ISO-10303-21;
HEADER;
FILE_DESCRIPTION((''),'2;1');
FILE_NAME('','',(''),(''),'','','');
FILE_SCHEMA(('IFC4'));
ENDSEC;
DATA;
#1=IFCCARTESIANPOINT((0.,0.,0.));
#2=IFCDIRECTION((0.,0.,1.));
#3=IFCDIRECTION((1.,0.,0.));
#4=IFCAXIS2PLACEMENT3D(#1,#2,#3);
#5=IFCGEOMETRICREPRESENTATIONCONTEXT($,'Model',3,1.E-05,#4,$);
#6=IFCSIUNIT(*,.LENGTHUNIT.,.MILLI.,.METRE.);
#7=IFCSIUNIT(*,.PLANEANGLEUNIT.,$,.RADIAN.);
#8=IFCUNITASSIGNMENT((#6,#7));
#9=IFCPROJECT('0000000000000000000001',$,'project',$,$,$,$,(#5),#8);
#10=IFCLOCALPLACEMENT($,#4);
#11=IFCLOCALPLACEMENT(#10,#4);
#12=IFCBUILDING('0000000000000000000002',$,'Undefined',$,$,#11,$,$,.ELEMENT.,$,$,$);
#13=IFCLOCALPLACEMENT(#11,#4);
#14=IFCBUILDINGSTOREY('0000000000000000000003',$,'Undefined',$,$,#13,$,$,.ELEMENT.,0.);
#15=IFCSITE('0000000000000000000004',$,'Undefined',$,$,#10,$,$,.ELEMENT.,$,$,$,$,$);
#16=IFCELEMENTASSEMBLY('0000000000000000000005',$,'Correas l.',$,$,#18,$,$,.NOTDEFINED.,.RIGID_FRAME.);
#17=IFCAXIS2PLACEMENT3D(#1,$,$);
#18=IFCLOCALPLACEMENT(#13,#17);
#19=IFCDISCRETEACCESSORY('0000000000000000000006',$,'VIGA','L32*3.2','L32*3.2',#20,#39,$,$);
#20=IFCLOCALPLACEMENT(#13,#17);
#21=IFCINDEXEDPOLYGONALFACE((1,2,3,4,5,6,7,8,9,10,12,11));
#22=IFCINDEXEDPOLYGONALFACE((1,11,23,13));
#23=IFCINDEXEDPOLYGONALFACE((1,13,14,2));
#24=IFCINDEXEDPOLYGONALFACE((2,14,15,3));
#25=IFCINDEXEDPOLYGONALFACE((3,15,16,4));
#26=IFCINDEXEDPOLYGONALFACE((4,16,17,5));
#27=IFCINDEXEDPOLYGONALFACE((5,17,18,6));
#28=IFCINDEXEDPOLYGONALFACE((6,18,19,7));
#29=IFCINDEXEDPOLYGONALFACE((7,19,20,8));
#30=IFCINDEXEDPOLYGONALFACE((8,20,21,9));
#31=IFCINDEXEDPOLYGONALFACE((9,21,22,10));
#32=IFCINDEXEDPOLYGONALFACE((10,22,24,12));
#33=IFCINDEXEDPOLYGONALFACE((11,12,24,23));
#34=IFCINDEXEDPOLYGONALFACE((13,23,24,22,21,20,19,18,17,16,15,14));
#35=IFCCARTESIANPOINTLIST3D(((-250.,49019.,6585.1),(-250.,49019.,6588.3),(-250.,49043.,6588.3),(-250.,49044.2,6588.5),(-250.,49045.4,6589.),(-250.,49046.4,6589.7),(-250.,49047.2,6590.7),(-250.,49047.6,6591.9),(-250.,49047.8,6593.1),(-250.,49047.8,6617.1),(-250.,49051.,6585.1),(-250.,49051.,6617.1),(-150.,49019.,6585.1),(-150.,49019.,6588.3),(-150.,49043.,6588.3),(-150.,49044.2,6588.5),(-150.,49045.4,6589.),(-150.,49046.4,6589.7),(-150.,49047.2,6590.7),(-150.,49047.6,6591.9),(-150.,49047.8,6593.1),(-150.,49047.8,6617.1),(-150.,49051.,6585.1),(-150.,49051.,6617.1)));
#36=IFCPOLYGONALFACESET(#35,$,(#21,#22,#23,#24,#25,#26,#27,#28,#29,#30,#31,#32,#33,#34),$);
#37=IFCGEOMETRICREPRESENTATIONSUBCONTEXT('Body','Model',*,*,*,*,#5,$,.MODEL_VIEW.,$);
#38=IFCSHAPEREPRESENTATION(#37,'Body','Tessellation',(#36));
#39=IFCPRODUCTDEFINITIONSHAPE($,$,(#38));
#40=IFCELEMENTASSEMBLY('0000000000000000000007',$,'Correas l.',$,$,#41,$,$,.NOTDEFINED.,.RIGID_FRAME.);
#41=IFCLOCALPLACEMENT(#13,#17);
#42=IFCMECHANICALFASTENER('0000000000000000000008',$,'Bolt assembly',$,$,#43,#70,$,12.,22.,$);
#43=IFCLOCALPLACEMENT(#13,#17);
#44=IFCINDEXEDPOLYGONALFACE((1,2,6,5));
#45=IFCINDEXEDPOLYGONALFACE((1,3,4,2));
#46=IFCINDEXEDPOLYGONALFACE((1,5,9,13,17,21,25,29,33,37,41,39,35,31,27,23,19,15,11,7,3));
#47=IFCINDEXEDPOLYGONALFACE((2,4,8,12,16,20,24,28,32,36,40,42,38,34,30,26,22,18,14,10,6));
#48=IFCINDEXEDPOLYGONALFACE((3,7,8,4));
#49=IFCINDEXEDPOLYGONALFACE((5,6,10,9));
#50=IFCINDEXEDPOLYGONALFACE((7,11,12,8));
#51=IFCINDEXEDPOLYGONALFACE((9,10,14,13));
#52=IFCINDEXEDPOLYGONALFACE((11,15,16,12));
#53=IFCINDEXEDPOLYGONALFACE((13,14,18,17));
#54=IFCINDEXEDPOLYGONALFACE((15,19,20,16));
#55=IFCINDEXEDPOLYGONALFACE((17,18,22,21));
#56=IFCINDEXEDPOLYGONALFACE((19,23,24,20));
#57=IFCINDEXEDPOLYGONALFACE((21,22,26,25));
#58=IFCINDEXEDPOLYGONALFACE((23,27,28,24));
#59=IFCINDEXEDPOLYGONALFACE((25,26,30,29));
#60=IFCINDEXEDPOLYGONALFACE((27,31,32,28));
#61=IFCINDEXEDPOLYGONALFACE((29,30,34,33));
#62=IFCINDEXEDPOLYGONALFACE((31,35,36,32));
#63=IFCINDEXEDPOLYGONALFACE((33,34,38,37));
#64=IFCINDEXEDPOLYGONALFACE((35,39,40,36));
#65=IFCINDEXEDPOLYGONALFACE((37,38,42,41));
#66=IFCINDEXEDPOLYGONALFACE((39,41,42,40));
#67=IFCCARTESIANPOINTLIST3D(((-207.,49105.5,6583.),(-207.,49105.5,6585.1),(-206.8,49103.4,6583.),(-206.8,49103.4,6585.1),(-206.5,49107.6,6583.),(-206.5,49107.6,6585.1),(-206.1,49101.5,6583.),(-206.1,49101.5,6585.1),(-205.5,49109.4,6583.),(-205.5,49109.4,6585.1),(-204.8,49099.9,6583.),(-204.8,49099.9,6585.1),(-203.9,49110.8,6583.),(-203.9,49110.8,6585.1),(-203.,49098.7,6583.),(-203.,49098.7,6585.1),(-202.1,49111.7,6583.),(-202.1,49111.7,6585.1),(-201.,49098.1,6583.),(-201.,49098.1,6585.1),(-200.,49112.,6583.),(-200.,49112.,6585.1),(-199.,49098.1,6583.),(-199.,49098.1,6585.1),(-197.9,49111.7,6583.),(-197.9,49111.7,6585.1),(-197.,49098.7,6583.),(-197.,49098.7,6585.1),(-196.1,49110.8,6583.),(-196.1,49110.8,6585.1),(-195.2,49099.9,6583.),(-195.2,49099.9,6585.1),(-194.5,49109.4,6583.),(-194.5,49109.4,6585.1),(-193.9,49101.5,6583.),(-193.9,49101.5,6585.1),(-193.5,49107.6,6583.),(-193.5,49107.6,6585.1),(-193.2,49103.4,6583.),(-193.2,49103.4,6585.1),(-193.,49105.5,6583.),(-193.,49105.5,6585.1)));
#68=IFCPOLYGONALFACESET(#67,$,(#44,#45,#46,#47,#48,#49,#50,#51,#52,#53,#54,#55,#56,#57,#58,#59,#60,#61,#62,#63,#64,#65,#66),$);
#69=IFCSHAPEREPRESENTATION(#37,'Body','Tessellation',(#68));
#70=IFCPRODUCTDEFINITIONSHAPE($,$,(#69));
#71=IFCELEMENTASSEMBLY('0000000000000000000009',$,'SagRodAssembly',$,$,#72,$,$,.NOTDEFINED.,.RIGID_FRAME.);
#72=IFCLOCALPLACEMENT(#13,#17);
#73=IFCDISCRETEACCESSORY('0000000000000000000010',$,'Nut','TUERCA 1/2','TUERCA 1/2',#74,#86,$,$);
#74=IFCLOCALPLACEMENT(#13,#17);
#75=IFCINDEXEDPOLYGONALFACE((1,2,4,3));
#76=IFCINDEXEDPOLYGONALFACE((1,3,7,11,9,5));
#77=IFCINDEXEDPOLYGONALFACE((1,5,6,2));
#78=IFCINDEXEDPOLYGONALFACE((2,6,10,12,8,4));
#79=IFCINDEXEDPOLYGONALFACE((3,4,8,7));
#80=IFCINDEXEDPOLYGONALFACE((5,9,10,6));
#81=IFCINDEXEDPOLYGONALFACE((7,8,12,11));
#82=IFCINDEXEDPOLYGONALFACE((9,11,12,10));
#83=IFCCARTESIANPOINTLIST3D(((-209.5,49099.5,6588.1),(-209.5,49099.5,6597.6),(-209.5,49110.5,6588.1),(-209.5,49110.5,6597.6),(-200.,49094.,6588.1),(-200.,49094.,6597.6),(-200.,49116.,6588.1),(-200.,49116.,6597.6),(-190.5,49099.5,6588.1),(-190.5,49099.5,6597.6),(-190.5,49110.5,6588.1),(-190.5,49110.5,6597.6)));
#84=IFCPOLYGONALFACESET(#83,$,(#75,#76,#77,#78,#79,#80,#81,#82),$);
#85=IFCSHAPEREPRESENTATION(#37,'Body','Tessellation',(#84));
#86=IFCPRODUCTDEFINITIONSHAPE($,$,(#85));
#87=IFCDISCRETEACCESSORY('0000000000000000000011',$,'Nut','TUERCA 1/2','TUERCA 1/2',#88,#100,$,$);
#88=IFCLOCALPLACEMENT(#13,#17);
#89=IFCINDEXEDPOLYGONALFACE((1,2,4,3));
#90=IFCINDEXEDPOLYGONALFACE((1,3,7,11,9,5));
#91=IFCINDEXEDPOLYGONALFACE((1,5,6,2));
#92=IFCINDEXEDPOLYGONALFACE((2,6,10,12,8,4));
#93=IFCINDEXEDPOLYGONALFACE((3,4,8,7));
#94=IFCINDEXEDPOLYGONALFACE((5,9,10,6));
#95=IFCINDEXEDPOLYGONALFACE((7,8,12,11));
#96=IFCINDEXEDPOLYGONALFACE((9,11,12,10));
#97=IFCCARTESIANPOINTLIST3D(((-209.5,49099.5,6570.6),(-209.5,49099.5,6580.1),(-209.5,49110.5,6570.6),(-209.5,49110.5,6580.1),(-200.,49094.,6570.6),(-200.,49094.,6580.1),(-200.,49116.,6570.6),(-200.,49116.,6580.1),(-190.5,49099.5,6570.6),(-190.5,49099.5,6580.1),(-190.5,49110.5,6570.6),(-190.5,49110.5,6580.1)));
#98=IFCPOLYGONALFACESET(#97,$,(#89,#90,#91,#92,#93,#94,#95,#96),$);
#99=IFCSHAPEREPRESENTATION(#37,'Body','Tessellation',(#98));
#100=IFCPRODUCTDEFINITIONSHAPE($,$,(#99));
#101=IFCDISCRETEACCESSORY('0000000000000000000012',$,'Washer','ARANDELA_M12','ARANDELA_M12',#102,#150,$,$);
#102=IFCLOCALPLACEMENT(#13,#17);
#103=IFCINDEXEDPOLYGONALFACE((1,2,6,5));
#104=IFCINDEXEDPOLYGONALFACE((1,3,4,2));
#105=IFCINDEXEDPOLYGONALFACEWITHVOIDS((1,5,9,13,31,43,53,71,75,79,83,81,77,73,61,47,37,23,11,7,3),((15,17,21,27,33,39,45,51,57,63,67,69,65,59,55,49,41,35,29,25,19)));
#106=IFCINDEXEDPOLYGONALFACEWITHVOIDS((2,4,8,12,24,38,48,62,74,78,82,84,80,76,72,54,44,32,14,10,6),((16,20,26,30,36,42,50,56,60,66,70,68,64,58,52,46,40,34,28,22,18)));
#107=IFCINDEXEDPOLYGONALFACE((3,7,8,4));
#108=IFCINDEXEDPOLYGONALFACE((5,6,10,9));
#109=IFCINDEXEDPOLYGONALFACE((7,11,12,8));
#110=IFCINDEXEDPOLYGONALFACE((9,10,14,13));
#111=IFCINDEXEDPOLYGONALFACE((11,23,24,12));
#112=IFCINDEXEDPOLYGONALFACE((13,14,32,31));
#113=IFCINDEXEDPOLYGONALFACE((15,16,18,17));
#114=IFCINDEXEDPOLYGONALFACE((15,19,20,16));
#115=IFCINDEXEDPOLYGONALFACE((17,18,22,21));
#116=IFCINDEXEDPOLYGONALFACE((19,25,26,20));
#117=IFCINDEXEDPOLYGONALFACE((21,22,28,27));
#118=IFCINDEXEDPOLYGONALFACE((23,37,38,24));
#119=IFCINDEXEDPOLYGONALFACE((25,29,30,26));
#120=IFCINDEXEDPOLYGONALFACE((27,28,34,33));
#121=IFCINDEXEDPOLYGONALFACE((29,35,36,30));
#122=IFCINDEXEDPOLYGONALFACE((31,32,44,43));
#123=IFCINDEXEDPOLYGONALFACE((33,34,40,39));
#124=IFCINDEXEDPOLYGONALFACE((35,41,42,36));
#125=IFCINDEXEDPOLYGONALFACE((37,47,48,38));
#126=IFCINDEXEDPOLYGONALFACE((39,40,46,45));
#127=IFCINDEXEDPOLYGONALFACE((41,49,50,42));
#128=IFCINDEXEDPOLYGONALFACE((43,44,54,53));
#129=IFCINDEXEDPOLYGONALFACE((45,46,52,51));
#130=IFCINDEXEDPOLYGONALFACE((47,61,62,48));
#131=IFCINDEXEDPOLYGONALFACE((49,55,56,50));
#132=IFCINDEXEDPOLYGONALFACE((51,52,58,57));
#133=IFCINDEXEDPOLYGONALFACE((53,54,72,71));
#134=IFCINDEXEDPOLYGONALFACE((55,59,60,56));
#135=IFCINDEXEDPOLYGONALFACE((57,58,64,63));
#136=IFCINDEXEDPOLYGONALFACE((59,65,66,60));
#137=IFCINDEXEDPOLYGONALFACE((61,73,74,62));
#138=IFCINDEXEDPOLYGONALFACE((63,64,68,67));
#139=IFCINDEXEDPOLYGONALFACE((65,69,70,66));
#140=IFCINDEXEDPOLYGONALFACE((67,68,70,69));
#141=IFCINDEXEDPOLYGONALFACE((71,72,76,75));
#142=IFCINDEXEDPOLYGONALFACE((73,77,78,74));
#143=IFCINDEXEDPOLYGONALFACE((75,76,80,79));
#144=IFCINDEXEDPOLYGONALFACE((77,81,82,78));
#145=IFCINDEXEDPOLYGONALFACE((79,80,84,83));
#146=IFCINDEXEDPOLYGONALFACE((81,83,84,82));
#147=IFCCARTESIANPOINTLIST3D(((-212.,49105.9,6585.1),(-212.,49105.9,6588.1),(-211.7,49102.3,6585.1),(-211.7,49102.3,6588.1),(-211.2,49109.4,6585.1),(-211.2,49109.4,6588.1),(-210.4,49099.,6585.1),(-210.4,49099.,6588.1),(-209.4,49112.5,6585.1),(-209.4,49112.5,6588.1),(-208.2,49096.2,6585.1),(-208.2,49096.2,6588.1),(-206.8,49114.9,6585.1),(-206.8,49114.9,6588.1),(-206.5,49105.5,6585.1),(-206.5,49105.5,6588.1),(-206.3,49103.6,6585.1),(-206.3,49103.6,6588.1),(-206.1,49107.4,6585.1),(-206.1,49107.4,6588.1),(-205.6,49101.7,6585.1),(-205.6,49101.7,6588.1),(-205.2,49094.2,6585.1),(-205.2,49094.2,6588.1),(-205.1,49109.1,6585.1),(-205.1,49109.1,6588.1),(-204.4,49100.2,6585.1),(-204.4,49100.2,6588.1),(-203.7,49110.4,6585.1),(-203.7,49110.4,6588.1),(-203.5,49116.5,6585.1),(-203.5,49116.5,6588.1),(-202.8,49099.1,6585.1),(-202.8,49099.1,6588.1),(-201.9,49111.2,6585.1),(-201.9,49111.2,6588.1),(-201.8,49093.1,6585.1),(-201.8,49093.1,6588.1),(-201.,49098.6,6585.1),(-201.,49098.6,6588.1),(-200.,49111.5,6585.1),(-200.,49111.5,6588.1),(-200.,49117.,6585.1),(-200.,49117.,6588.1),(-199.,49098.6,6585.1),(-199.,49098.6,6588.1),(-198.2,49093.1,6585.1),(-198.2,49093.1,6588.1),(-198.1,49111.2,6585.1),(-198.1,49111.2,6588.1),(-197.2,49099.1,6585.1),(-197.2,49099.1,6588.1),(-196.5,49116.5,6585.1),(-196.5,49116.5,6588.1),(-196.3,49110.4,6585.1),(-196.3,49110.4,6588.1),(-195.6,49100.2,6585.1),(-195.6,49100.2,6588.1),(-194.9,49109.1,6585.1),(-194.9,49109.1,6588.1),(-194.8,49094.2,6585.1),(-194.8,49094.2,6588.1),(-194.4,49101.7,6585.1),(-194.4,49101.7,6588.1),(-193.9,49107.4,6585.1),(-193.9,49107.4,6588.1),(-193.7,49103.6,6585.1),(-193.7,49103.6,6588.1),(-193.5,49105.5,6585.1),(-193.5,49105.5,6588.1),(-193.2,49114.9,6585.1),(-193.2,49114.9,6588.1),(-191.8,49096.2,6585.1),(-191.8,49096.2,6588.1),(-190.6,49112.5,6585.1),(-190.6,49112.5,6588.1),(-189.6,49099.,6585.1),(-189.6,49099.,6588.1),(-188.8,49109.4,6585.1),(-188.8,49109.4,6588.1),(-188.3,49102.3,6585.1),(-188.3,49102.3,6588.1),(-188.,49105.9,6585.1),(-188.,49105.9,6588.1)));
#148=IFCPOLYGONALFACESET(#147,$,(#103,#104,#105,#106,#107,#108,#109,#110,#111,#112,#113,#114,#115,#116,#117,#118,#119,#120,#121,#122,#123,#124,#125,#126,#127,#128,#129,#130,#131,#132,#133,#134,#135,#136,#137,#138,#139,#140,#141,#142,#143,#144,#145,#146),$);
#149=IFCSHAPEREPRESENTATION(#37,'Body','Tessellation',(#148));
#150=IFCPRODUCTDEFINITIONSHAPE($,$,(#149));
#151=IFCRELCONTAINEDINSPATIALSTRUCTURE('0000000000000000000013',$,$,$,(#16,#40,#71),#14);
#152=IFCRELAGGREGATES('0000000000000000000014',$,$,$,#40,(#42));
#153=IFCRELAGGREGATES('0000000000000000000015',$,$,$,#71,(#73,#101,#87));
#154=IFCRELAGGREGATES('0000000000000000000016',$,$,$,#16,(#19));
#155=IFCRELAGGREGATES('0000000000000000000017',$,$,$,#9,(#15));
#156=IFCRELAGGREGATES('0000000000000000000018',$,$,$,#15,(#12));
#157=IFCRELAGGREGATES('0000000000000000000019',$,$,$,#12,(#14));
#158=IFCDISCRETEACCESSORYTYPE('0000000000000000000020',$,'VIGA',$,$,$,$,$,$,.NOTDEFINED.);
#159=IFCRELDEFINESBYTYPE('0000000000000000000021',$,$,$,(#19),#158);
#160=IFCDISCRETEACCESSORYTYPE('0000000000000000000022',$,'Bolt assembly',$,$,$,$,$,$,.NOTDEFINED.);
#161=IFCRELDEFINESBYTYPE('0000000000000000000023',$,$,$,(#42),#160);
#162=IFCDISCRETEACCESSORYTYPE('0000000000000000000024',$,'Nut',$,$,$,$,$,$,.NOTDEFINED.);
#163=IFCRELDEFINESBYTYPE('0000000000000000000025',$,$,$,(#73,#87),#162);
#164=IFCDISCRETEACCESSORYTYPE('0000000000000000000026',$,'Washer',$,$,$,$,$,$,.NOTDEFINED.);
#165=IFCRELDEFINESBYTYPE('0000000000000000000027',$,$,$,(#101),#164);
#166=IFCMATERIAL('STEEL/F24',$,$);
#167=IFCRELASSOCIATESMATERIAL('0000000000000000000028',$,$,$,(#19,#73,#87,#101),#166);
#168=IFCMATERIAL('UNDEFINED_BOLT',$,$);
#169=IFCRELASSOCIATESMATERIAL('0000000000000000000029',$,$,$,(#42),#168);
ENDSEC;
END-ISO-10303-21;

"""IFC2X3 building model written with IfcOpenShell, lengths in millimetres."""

from ifc_helpers import new_model, si_unit, frame, origin_with_axes, origin_2d_with_axis, place, context, subcontext, project, spatial, polyline, circle, hollow_circle, l_section, outline, extrude, source, transform, mapped, material, type_object, element, aggregate, save


model = new_model("IFC2X3")

# Units and contexts
model_context = context("Model", 3, precision=1e-05, world=origin_with_axes())
body_context = subcontext(model_context, "Body", "Model", "MODEL_VIEW")
ifc_project = project(units=[si_unit("LENGTHUNIT", "METRE", prefix="MILLI"), si_unit("PLANEANGLEUNIT", "RADIAN")], contexts=[model_context])

# Site, building, storey
site_placement = place(None, origin_with_axes())
site = spatial("IfcSite", under=ifc_project, at=site_placement, Name="Undefined", CompositionType="ELEMENT")
building_placement = place(site_placement, origin_with_axes())
building = spatial("IfcBuilding", under=site, at=building_placement, Name="Undefined", CompositionType="ELEMENT")
storey_placement = place(building_placement, origin_with_axes())
storey = spatial("IfcBuildingStorey", under=building, at=storey_placement, Name="Undefined", CompositionType="ELEMENT", Elevation=0.0)

# Shared definitions
ifc_material_1 = material(Name="STEEL/F24")

# Element assembly, discrete accessory
assembly_1_placement = place(storey_placement, origin_with_axes())
assembly_1 = element("IfcElementAssembly", 1, at=assembly_1_placement, inside=storey, Name="Correas l.", AssemblyPlace="NOTDEFINED", PredefinedType="RIGID_FRAME")
discrete_accessory_type_1 = type_object("IfcDiscreteAccessoryType", Name="VIGA")
discrete_accessory_1_placement = place(assembly_1_placement, frame((-250.0, 49035.0, 6601.1), z_axis=(0.0, 0.0, 1.0), x_axis=(1.0, 0.0, 0.0)))
discrete_accessory_1 = element("IfcDiscreteAccessory", 2, at=discrete_accessory_1_placement, type_object=discrete_accessory_type_1, material=ifc_material_1, Name="VIGA", Description="L32*3.2", ObjectType="L32*3.2", context=body_context, shape_type="SweptSolid", body=[
    extrude(l_section(Depth=32.0, Width=32.0, Thickness=3.2, FilletRadius=4.8, at=origin_2d_with_axis()), frame((100.0, 0.0, 0.0), z_axis=(-1.0, 0.0, 0.0), x_axis=(0.0, -1.0, 0.0)), (0.0, 0.0, 1.0), 100.0),
])

# Element assembly, mechanical fastener
assembly_2_placement = place(storey_placement, origin_with_axes())
assembly_2 = element("IfcElementAssembly", 3, at=assembly_2_placement, inside=storey, Name="Correas l.", AssemblyPlace="NOTDEFINED", PredefinedType="RIGID_FRAME")
ifc_material_2 = material(Name="UNDEFINED_BOLT")
discrete_accessory_type_2 = type_object("IfcDiscreteAccessoryType", Name="Bolt assembly")
shared_shape_1 = source(origin_with_axes(), body_context, "Body", "SweptSolid", [
    extrude(circle(Radius=7.0, at=origin_2d_with_axis()), frame((0.0, -1.0, 0.0), z_axis=(0.0, 1.0, 0.0), x_axis=(1.0, 0.0, 0.0)), (0.0, 0.0, 1.0), 2.1),
])
mechanical_fastener_1_placement = place(assembly_2_placement, frame((-200.0, 49105.0, 6584.1), z_axis=(-1.0, 0.0, 0.0), x_axis=(0.0, 1.0, 0.0)))
mechanical_fastener_1 = element("IfcMechanicalFastener", 4, at=mechanical_fastener_1_placement, type_object=discrete_accessory_type_2, material=ifc_material_2, Name="Bolt assembly", NominalDiameter=12.0, NominalLength=22.0, context=body_context, shape_type="MappedRepresentation", body=[
    mapped(shared_shape_1, transform((0.0, 0.0, 0.0))),
])
aggregate(assembly_2, [mechanical_fastener_1])

# Element assembly, discrete accessories
assembly_3_placement = place(storey_placement, origin_with_axes())
assembly_3 = element("IfcElementAssembly", 5, at=assembly_3_placement, inside=storey, Name="SagRodAssembly", AssemblyPlace="NOTDEFINED", PredefinedType="RIGID_FRAME")
discrete_accessory_type_3 = type_object("IfcDiscreteAccessoryType", Name="Nut")
discrete_accessory_2_placement = place(assembly_3_placement, frame((-200.0, 49105.0, 6588.1), z_axis=(0.0, 0.0, 1.0), x_axis=(1.0, 0.0, 0.0)))
discrete_accessory_2 = element("IfcDiscreteAccessory", 6, at=discrete_accessory_2_placement, type_object=discrete_accessory_type_3, material=ifc_material_1, Name="Nut", Description="TUERCA 1/2", ObjectType="TUERCA 1/2", context=body_context, shape_type="SweptSolid", body=[
    extrude(outline(polyline([(-5.5, 9.5), (5.5, 9.5), (11.0, 0.0), (5.5, -9.5), (-5.5, -9.5), (-11.0, 0.0), (-5.5, 9.5)])), frame((0.0, 0.0, 9.5), z_axis=(0.0, 0.0, -1.0), x_axis=(0.0, 1.0, 0.0)), (0.0, 0.0, 1.0), 9.5),
])
discrete_accessory_3_placement = place(assembly_3_placement, frame((-200.0, 49105.0, 6570.6), z_axis=(0.0, 0.0, 1.0), x_axis=(1.0, 0.0, 0.0)))
discrete_accessory_3 = element("IfcDiscreteAccessory", 7, at=discrete_accessory_3_placement, type_object=discrete_accessory_type_3, material=ifc_material_1, Name="Nut", Description="TUERCA 1/2", ObjectType="TUERCA 1/2", context=body_context, shape_type="SweptSolid", body=[
    extrude(outline(polyline([(-5.5, 9.5), (5.5, 9.5), (11.0, 0.0), (5.5, -9.5), (-5.5, -9.5), (-11.0, 0.0), (-5.5, 9.5)])), frame((0.0, 0.0, 9.5), z_axis=(0.0, 0.0, -1.0), x_axis=(0.0, 1.0, 0.0)), (0.0, 0.0, 1.0), 9.5),
])
discrete_accessory_type_4 = type_object("IfcDiscreteAccessoryType", Name="Washer")
discrete_accessory_4_placement = place(assembly_3_placement, frame((-200.0, 49105.0, 6585.1), z_axis=(0.0, 0.0, 1.0), x_axis=(1.0, 0.0, 0.0)))
discrete_accessory_4 = element("IfcDiscreteAccessory", 8, at=discrete_accessory_4_placement, type_object=discrete_accessory_type_4, material=ifc_material_1, Name="Washer", Description="ARANDELA_M12", ObjectType="ARANDELA_M12", context=body_context, shape_type="SweptSolid", body=[
    extrude(hollow_circle(Radius=12.0, WallThickness=5.5, at=origin_2d_with_axis()), frame((0.0, 0.0, 3.0), z_axis=(0.0, 0.0, -1.0), x_axis=(0.0, 1.0, 0.0)), (0.0, 0.0, 1.0), 3.0),
])
aggregate(assembly_3, [discrete_accessory_2, discrete_accessory_4, discrete_accessory_3])

aggregate(assembly_1, [discrete_accessory_1])

save(model, "model.ifc")
